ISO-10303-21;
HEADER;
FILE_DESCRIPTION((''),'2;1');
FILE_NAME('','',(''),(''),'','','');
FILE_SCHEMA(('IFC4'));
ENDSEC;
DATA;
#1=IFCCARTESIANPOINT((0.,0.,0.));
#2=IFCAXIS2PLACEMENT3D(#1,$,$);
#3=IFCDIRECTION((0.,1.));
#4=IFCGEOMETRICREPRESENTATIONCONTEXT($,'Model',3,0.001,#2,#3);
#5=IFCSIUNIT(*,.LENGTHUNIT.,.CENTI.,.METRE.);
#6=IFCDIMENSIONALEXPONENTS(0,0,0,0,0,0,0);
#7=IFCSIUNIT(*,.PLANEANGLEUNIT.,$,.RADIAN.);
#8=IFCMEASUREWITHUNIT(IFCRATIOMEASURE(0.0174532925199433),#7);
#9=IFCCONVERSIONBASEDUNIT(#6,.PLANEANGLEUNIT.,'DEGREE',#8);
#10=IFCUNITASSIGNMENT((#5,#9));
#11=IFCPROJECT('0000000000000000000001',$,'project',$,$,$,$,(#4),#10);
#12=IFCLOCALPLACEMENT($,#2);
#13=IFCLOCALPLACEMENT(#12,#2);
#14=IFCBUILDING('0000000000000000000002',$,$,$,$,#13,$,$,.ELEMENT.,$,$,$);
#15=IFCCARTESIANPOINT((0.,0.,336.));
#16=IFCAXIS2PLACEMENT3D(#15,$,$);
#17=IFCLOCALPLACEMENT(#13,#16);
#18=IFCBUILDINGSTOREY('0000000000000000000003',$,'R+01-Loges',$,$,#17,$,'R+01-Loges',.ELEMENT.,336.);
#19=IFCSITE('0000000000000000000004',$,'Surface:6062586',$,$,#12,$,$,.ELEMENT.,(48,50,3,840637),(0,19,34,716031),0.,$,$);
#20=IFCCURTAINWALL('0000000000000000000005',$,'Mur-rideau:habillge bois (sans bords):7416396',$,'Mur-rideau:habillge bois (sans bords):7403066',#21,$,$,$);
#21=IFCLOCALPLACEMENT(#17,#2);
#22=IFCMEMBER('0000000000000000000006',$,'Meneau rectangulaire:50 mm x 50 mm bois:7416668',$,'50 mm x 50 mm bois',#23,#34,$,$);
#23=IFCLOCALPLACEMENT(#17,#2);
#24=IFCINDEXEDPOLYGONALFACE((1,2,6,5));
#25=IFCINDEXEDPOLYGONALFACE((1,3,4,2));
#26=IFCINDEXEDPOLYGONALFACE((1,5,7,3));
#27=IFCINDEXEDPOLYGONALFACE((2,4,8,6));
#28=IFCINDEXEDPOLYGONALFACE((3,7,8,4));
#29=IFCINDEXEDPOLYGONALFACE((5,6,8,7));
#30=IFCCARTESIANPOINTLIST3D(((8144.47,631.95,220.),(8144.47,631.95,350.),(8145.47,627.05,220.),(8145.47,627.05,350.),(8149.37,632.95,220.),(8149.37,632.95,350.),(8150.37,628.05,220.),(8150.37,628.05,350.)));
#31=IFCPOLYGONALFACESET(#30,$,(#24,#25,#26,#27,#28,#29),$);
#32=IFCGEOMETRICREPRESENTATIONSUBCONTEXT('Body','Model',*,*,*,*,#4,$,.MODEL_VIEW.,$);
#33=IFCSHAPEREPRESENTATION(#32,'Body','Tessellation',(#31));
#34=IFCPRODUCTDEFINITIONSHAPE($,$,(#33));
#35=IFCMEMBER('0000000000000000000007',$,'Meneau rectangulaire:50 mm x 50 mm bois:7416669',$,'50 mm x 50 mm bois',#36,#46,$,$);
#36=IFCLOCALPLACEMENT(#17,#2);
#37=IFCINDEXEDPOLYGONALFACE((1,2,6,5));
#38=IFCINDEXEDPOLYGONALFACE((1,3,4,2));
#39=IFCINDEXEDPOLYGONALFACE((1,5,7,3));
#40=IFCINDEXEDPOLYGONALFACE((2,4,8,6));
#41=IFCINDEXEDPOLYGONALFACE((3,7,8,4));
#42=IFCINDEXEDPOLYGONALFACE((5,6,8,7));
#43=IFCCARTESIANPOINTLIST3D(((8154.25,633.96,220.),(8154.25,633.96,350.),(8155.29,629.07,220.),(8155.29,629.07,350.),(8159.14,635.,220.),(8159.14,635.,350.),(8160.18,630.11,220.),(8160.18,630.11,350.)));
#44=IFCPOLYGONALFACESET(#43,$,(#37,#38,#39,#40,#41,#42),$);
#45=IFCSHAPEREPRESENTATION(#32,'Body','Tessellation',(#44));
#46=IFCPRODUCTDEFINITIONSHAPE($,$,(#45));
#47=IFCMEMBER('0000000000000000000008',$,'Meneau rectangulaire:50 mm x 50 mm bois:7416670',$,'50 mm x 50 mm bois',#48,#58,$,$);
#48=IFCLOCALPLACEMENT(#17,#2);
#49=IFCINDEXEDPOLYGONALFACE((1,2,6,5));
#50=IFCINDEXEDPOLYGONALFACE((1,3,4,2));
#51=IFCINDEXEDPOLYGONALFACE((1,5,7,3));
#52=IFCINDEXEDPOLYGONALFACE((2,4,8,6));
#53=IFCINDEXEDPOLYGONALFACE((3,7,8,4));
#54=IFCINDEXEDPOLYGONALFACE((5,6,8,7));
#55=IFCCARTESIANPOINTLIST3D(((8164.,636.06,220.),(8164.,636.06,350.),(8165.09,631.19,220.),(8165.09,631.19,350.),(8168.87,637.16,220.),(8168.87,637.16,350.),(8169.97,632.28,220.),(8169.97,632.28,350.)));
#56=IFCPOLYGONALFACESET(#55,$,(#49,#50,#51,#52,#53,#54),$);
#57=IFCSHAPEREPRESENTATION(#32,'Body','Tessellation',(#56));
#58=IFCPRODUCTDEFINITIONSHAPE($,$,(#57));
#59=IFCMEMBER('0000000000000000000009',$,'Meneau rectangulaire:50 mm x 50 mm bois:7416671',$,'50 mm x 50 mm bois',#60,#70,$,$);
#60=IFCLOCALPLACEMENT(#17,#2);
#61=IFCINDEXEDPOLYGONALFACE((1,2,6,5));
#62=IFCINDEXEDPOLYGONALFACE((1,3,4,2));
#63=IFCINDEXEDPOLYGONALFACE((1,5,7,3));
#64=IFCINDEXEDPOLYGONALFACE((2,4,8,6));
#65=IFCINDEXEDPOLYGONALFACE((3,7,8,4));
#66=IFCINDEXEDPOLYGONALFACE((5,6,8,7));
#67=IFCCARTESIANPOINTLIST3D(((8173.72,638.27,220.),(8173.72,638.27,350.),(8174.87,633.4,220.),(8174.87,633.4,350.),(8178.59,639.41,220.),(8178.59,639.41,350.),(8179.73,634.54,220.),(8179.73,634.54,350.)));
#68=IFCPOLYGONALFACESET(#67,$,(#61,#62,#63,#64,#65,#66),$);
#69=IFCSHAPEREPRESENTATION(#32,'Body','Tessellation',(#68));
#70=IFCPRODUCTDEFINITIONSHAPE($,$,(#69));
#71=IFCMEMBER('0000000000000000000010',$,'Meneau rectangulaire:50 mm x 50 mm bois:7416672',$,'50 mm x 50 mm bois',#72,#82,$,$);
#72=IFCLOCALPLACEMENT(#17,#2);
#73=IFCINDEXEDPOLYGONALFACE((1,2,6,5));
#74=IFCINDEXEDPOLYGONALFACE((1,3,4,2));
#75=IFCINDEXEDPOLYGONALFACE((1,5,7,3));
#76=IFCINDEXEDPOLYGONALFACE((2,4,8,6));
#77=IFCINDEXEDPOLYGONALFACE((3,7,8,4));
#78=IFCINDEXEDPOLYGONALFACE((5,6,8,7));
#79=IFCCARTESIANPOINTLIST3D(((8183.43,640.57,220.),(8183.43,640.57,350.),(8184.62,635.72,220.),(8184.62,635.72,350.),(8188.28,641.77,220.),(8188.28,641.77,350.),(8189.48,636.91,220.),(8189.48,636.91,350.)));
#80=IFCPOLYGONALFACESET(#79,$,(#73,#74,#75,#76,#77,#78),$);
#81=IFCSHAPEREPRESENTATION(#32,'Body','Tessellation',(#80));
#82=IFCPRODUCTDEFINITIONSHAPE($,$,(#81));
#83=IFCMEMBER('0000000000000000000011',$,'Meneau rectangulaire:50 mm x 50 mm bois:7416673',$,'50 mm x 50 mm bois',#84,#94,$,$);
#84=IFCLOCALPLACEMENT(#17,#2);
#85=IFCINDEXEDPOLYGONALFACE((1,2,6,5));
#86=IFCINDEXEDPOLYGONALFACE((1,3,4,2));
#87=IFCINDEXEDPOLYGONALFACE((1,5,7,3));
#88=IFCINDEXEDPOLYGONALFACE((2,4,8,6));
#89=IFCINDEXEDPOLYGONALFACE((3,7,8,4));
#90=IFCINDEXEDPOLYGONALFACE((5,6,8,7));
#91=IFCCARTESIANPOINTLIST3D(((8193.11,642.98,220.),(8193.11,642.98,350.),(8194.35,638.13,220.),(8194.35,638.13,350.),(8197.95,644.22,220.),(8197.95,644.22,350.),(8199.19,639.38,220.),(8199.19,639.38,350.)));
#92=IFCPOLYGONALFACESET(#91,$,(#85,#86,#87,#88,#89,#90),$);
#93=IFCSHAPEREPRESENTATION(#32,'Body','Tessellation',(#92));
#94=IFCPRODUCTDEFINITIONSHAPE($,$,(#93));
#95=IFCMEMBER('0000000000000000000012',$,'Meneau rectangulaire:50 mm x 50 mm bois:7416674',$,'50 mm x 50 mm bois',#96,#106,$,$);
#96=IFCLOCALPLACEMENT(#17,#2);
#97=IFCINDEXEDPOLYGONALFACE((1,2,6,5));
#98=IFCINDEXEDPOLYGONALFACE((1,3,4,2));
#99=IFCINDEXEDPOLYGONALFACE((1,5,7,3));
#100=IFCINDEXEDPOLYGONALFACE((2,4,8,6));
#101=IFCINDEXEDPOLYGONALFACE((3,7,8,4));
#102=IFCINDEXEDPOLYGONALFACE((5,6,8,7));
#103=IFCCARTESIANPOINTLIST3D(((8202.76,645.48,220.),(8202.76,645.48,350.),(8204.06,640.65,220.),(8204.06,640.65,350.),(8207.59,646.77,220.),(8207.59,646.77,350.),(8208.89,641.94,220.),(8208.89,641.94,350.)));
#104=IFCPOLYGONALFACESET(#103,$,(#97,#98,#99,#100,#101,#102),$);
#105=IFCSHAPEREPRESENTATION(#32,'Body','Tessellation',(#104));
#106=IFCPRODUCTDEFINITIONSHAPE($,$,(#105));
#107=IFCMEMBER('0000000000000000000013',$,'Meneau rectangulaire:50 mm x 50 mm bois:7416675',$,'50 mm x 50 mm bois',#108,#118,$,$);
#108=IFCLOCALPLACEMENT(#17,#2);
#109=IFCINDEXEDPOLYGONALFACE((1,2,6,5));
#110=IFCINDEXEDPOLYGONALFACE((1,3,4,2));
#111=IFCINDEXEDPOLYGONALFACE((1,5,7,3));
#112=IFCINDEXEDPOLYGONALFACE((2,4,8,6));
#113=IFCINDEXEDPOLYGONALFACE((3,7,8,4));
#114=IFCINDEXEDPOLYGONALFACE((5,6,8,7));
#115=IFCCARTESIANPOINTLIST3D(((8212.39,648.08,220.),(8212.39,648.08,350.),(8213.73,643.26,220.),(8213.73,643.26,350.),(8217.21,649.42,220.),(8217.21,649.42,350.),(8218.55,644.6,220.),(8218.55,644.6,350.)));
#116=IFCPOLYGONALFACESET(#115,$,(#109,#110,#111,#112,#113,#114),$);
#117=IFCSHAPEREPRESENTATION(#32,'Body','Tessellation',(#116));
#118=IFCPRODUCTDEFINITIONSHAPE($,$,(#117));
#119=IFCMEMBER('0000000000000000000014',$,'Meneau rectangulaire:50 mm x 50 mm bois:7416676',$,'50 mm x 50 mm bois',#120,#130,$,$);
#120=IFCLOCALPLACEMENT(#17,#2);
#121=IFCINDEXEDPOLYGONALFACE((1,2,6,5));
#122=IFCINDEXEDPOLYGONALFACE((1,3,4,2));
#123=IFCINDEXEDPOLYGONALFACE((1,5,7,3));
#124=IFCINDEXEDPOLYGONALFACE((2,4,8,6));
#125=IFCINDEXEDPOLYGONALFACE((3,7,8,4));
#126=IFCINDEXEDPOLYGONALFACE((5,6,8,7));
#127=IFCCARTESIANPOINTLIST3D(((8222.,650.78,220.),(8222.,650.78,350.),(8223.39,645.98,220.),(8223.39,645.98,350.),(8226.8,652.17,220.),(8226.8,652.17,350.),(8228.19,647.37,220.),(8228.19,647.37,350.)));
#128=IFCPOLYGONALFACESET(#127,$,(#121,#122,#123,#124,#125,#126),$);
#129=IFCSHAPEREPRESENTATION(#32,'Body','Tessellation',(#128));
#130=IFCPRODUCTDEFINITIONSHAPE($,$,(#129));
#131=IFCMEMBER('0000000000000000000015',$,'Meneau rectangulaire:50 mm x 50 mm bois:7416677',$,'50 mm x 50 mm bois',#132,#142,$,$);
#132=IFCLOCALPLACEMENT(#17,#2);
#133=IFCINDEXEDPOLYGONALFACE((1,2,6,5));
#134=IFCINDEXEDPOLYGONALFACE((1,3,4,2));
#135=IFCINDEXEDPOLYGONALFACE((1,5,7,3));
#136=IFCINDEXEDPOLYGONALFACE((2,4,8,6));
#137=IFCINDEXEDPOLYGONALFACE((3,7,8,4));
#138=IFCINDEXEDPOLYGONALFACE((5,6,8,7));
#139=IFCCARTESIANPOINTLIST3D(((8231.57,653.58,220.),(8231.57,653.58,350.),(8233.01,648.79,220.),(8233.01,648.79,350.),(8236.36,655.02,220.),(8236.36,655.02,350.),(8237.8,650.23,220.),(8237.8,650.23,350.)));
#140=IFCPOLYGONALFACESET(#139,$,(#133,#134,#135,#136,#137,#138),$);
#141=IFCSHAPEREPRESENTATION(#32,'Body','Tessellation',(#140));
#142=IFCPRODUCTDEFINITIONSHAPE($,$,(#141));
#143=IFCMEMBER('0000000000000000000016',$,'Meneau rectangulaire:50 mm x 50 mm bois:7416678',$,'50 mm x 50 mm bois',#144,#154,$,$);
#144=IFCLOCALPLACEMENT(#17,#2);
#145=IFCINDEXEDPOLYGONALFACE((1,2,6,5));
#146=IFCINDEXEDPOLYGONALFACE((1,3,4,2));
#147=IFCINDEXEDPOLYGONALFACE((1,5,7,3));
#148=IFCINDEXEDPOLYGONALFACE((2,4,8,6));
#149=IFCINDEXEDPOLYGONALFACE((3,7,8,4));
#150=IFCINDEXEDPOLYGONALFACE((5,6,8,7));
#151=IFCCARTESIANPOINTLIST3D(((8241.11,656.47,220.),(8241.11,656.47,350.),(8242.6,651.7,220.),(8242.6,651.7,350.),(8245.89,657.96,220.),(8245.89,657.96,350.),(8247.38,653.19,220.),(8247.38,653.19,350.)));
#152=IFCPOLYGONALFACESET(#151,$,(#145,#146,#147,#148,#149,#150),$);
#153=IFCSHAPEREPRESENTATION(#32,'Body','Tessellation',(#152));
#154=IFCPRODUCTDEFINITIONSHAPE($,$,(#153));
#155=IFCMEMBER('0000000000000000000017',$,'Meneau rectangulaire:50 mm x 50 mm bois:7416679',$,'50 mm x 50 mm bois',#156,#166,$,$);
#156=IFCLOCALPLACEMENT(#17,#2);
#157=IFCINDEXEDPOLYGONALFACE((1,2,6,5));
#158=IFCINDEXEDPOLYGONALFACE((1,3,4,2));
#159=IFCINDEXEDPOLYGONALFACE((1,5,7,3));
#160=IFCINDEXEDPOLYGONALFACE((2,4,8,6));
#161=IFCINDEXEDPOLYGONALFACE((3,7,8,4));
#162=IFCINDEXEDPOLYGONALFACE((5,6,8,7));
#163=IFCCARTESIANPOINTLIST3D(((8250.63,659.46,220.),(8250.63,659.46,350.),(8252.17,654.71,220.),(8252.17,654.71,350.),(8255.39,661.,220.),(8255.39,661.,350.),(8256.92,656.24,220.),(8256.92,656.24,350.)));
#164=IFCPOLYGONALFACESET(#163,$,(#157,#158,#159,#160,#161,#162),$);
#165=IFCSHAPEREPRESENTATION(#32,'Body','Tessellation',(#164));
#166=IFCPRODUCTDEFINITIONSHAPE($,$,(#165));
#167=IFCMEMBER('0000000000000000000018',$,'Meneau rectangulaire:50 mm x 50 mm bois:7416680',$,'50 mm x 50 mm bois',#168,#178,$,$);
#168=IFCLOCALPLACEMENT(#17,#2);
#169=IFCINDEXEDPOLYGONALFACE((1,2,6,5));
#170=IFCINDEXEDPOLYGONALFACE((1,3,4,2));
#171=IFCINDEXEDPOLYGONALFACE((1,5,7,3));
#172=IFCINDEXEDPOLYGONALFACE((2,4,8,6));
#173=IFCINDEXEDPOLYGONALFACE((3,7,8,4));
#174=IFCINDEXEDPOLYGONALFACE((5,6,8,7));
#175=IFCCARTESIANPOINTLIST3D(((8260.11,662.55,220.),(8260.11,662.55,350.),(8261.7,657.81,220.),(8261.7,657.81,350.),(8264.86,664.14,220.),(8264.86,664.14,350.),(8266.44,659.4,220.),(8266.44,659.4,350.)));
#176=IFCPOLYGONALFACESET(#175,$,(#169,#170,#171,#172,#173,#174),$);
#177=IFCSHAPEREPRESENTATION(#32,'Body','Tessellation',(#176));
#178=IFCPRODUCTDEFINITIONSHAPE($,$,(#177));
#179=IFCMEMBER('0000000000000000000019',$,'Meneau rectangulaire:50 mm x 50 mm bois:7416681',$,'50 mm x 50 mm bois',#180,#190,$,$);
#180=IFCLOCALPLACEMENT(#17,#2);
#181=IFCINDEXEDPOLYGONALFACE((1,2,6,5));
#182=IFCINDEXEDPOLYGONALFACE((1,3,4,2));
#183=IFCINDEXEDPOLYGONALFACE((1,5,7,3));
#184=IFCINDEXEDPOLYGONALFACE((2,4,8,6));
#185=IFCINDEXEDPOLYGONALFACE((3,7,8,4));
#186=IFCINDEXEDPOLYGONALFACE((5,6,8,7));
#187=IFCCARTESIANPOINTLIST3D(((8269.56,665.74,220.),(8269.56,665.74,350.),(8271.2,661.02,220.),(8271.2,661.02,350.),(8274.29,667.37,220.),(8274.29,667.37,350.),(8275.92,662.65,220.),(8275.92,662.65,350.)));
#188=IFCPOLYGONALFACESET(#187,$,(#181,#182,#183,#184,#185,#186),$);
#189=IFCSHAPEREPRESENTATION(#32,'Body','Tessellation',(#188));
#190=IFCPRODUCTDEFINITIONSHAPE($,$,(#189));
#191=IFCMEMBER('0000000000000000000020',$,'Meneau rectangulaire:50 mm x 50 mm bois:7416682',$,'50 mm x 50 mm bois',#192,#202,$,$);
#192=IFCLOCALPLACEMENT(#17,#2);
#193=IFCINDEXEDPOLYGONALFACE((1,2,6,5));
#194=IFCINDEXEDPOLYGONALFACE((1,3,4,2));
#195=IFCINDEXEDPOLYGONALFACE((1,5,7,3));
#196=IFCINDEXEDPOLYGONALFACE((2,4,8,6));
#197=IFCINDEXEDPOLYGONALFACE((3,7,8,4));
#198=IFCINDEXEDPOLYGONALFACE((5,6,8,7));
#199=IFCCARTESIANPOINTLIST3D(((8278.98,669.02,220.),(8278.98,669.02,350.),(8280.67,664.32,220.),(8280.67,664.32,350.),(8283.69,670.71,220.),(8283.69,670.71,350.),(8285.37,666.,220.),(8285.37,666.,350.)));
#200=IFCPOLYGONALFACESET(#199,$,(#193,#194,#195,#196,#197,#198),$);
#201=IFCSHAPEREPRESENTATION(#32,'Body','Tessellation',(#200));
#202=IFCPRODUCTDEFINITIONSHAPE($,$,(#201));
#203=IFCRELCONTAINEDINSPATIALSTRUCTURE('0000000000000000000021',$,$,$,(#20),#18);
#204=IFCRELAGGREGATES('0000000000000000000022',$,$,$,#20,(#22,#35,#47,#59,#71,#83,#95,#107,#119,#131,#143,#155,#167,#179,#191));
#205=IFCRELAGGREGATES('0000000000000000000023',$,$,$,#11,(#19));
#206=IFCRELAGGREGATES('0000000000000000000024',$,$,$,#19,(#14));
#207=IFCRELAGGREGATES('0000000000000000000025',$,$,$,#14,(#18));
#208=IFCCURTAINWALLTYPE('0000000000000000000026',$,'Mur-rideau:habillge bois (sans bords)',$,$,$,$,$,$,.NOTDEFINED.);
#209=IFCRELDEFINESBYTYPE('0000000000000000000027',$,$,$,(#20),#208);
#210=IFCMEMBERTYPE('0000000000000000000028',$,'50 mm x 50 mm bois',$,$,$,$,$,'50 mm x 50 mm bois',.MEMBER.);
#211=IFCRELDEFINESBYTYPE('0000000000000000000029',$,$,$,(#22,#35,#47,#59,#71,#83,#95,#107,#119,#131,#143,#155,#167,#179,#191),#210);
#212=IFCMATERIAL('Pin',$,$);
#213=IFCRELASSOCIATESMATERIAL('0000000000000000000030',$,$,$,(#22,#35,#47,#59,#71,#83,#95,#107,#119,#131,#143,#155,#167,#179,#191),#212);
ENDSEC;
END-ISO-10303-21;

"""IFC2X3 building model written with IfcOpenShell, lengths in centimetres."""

from ifc_helpers import new_model, entity, si_unit, converted_unit, direction, frame, origin, origin_2d_with_axis, place, context, subcontext, project, spatial, rectangle, extrude, source, transform, mapped, material, type_object, type_shapes, element, aggregate, save


model = new_model("IFC2X3")

# Units and contexts
model_context = context("Model", 3, precision=0.001, world=origin(), true_north=direction((0.0, 1.0)))
body_context = subcontext(model_context, "Body", "Model", "MODEL_VIEW")
ifc_project = project(units=[si_unit("LENGTHUNIT", "METRE", prefix="CENTI"), converted_unit("PLANEANGLEUNIT", "DEGREE", entity("IfcRatioMeasure", 0.0174532925199433), si_unit("PLANEANGLEUNIT", "RADIAN"), dimensions=[0, 0, 0, 0, 0, 0, 0])], contexts=[model_context])

# Site, building, storey
site_placement = place(None, origin())
site = spatial("IfcSite", under=ifc_project, at=site_placement, Name="Surface:6062586", CompositionType="ELEMENT", RefLatitude=(48, 50, 3, 840637), RefLongitude=(0, 19, 34, 716031), RefElevation=0.0)
building_placement = place(site_placement, origin())
building = spatial("IfcBuilding", under=site, at=building_placement, CompositionType="ELEMENT")
storey_placement = place(building_placement, frame((0.0, 0.0, 336.0)))
storey = spatial("IfcBuildingStorey", under=building, at=storey_placement, Name="R+01-Loges", LongName="R+01-Loges", CompositionType="ELEMENT", Elevation=336.0)

# Curtain wall, members
curtain_wall_type_1 = type_object("IfcCurtainWallType", Name="Mur-rideau:habillge bois (sans bords)", PredefinedType="NOTDEFINED")
curtain_wall_1_placement = place(storey_placement, frame((0.0, 0.0, -336.0)))
curtain_wall_1 = element("IfcCurtainWall", 1, at=curtain_wall_1_placement, inside=storey, type_object=curtain_wall_type_1, Name="Mur-rideau:habillge bois (sans bords):7416396", ObjectType="Mur-rideau:habillge bois (sans bords):7403066")
ifc_material_1 = material(Name="Pin")
member_type = type_object("IfcMemberType", Name="50 mm x 50 mm bois", ElementType="50 mm x 50 mm bois", PredefinedType="MEMBER")
shared_shape_1 = source(origin(), body_context, "Body", "SweptSolid", [
    extrude(rectangle(XDim=5.0, YDim=5.0, at=origin_2d_with_axis()), frame((0.0, 0.0, -130.0), z_axis=(0.0, 0.0, 1.0), x_axis=(0.0, -1.0, 0.0)), (0.0, 0.0, 1.0), 130.0),
])
type_shapes(member_type, [shared_shape_1])
member_1_placement = place(storey_placement, frame((8147.42, 630.0, 220.0), z_axis=(0.0, 0.0, -1.0), x_axis=(0.980092, 0.198544, 0.0)))
member_1 = element("IfcMember", 2, at=member_1_placement, type_object=member_type, material=ifc_material_1, Name="Meneau rectangulaire:50 mm x 50 mm bois:7416668", ObjectType="50 mm x 50 mm bois", context=body_context, shape_type="MappedRepresentation", body=[
    mapped(shared_shape_1, transform((0.0, 0.0, 0.0), scale=1.0)),
])
member_2_placement = place(storey_placement, frame((8157.21, 632.04, 220.0), z_axis=(0.0, 0.0, -1.0), x_axis=(0.97801, 0.20856, 0.0)))
member_2 = element("IfcMember", 3, at=member_2_placement, type_object=member_type, material=ifc_material_1, Name="Meneau rectangulaire:50 mm x 50 mm bois:7416669", ObjectType="50 mm x 50 mm bois", context=body_context, shape_type="MappedRepresentation", body=[
    mapped(shared_shape_1, transform((0.0, 0.0, 0.0), scale=1.0)),
])
member_3_placement = place(storey_placement, frame((8166.98, 634.17, 220.0), z_axis=(0.0, 0.0, -1.0), x_axis=(0.975825, 0.218554, 0.0)))
member_3 = element("IfcMember", 4, at=member_3_placement, type_object=member_type, material=ifc_material_1, Name="Meneau rectangulaire:50 mm x 50 mm bois:7416670", ObjectType="50 mm x 50 mm bois", context=body_context, shape_type="MappedRepresentation", body=[
    mapped(shared_shape_1, transform((0.0, 0.0, 0.0), scale=1.0)),
])
member_4_placement = place(storey_placement, frame((8176.73, 636.41, 220.0), z_axis=(0.0, 0.0, -1.0), x_axis=(0.973538, 0.228525, 0.0)))
member_4 = element("IfcMember", 5, at=member_4_placement, type_object=member_type, material=ifc_material_1, Name="Meneau rectangulaire:50 mm x 50 mm bois:7416671", ObjectType="50 mm x 50 mm bois", context=body_context, shape_type="MappedRepresentation", body=[
    mapped(shared_shape_1, transform((0.0, 0.0, 0.0), scale=1.0)),
])
member_5_placement = place(storey_placement, frame((8186.45, 638.74, 220.0), z_axis=(0.0, 0.0, -1.0), x_axis=(0.971149, 0.238473, 0.0)))
member_5 = element("IfcMember", 6, at=member_5_placement, type_object=member_type, material=ifc_material_1, Name="Meneau rectangulaire:50 mm x 50 mm bois:7416672", ObjectType="50 mm x 50 mm bois", context=body_context, shape_type="MappedRepresentation", body=[
    mapped(shared_shape_1, transform((0.0, 0.0, 0.0), scale=1.0)),
])
member_6_placement = place(storey_placement, frame((8196.15, 641.18, 220.0), z_axis=(0.0, 0.0, -1.0), x_axis=(0.968659, 0.248395, 0.0)))
member_6 = element("IfcMember", 7, at=member_6_placement, type_object=member_type, material=ifc_material_1, Name="Meneau rectangulaire:50 mm x 50 mm bois:7416673", ObjectType="50 mm x 50 mm bois", context=body_context, shape_type="MappedRepresentation", body=[
    mapped(shared_shape_1, transform((0.0, 0.0, 0.0), scale=1.0)),
])
member_7_placement = place(storey_placement, frame((8205.82, 643.71, 220.0), z_axis=(0.0, 0.0, -1.0), x_axis=(0.966067, 0.258292, 0.0)))
member_7 = element("IfcMember", 8, at=member_7_placement, type_object=member_type, material=ifc_material_1, Name="Meneau rectangulaire:50 mm x 50 mm bois:7416674", ObjectType="50 mm x 50 mm bois", context=body_context, shape_type="MappedRepresentation", body=[
    mapped(shared_shape_1, transform((0.0, 0.0, 0.0), scale=1.0)),
])
member_8_placement = place(storey_placement, frame((8215.47, 646.34, 220.0), z_axis=(0.0, 0.0, -1.0), x_axis=(0.963374, 0.268161, 0.0)))
member_8 = element("IfcMember", 9, at=member_8_placement, type_object=member_type, material=ifc_material_1, Name="Meneau rectangulaire:50 mm x 50 mm bois:7416675", ObjectType="50 mm x 50 mm bois", context=body_context, shape_type="MappedRepresentation", body=[
    mapped(shared_shape_1, transform((0.0, 0.0, 0.0), scale=1.0)),
])
member_9_placement = place(storey_placement, frame((8225.09, 649.07, 220.0), z_axis=(0.0, 0.0, -1.0), x_axis=(0.96058, 0.278002, 0.0)))
member_9 = element("IfcMember", 10, at=member_9_placement, type_object=member_type, material=ifc_material_1, Name="Meneau rectangulaire:50 mm x 50 mm bois:7416676", ObjectType="50 mm x 50 mm bois", context=body_context, shape_type="MappedRepresentation", body=[
    mapped(shared_shape_1, transform((0.0, 0.0, 0.0), scale=1.0)),
])
member_10_placement = place(storey_placement, frame((8234.68, 651.9, 220.0), z_axis=(0.0, 0.0, -1.0), x_axis=(0.957686, 0.287815, 0.0)))
member_10 = element("IfcMember", 11, at=member_10_placement, type_object=member_type, material=ifc_material_1, Name="Meneau rectangulaire:50 mm x 50 mm bois:7416677", ObjectType="50 mm x 50 mm bois", context=body_context, shape_type="MappedRepresentation", body=[
    mapped(shared_shape_1, transform((0.0, 0.0, 0.0), scale=1.0)),
])
member_11_placement = place(storey_placement, frame((8244.25, 654.83, 220.0), z_axis=(0.0, 0.0, -1.0), x_axis=(0.954692, 0.297597, 0.0)))
member_11 = element("IfcMember", 12, at=member_11_placement, type_object=member_type, material=ifc_material_1, Name="Meneau rectangulaire:50 mm x 50 mm bois:7416678", ObjectType="50 mm x 50 mm bois", context=body_context, shape_type="MappedRepresentation", body=[
    mapped(shared_shape_1, transform((0.0, 0.0, 0.0), scale=1.0)),
])
member_12_placement = place(storey_placement, frame((8253.78, 657.85, 220.0), z_axis=(0.0, 0.0, -1.0), x_axis=(0.951597, 0.307348, 0.0)))
member_12 = element("IfcMember", 13, at=member_12_placement, type_object=member_type, material=ifc_material_1, Name="Meneau rectangulaire:50 mm x 50 mm bois:7416679", ObjectType="50 mm x 50 mm bois", context=body_context, shape_type="MappedRepresentation", body=[
    mapped(shared_shape_1, transform((0.0, 0.0, 0.0), scale=1.0)),
])
member_13_placement = place(storey_placement, frame((8263.28, 660.98, 220.0), z_axis=(0.0, 0.0, -1.0), x_axis=(0.948403, 0.317066, 0.0)))
member_13 = element("IfcMember", 14, at=member_13_placement, type_object=member_type, material=ifc_material_1, Name="Meneau rectangulaire:50 mm x 50 mm bois:7416680", ObjectType="50 mm x 50 mm bois", context=body_context, shape_type="MappedRepresentation", body=[
    mapped(shared_shape_1, transform((0.0, 0.0, 0.0), scale=1.0)),
])
member_14_placement = place(storey_placement, frame((8272.74, 664.2, 220.0), z_axis=(0.0, 0.0, -1.0), x_axis=(0.94511, 0.326752, 0.0)))
member_14 = element("IfcMember", 15, at=member_14_placement, type_object=member_type, material=ifc_material_1, Name="Meneau rectangulaire:50 mm x 50 mm bois:7416681", ObjectType="50 mm x 50 mm bois", context=body_context, shape_type="MappedRepresentation", body=[
    mapped(shared_shape_1, transform((0.0, 0.0, 0.0), scale=1.0)),
])
member_15_placement = place(storey_placement, frame((8282.18, 667.51, 220.0), z_axis=(0.0, 0.0, -1.0), x_axis=(0.941718, 0.336403, 0.0)))
member_15 = element("IfcMember", 16, at=member_15_placement, type_object=member_type, material=ifc_material_1, Name="Meneau rectangulaire:50 mm x 50 mm bois:7416682", ObjectType="50 mm x 50 mm bois", context=body_context, shape_type="MappedRepresentation", body=[
    mapped(shared_shape_1, transform((0.0, 0.0, 0.0), scale=1.0)),
])
aggregate(curtain_wall_1, [member_1, member_2, member_3, member_4, member_5, member_6, member_7, member_8, member_9, member_10, member_11, member_12, member_13, member_14, member_15])

save(model, "model.ifc")
